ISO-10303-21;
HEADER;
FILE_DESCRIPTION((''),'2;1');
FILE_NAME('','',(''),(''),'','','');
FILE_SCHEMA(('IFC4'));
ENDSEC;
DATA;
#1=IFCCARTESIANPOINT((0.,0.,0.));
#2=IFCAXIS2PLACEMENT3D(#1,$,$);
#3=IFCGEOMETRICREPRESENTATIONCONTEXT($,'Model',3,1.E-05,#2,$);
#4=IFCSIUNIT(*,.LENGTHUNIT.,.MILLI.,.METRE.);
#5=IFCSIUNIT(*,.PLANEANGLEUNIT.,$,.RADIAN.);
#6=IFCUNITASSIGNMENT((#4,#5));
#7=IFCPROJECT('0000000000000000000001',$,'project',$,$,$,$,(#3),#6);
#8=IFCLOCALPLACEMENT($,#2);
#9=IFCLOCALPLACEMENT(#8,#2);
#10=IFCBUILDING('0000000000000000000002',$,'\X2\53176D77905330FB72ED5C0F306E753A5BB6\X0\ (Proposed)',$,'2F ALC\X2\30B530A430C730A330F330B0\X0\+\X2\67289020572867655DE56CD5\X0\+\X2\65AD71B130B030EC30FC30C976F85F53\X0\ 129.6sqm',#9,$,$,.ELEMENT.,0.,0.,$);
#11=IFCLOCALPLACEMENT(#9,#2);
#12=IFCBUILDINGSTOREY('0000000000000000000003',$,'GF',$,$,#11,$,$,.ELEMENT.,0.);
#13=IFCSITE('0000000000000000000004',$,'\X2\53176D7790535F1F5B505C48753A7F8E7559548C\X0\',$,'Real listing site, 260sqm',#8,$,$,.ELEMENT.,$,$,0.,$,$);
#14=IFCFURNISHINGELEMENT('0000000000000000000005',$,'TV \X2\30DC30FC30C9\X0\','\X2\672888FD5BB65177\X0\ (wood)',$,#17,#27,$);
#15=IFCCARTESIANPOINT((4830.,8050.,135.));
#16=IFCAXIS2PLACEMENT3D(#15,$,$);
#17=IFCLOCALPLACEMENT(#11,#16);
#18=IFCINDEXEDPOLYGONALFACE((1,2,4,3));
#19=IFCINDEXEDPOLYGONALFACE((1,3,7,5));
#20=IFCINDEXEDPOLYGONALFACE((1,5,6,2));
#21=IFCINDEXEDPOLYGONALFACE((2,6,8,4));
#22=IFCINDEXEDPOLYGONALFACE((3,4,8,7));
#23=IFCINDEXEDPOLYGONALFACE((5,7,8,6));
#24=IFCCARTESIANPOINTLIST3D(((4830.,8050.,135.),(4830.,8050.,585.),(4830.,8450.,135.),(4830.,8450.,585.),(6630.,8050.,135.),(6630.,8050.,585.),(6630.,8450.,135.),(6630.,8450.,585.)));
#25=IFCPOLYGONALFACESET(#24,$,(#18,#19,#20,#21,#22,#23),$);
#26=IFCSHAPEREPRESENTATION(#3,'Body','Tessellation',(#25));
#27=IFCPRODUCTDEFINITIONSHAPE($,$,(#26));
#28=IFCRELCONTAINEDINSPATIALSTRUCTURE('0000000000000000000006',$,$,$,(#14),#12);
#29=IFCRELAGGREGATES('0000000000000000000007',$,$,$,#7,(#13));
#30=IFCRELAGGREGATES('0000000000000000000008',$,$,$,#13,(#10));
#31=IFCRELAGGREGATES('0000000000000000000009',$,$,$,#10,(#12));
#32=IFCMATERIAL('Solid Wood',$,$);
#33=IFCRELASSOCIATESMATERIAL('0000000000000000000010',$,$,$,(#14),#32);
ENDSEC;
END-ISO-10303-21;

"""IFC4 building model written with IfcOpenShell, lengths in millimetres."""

from ifc_helpers import new_model, si_unit, frame, frame_2d, origin, place, context, project, spatial, rectangle, extrude, material, element, save


model = new_model("IFC4")

# Units and contexts
model_context = context("Model", 3, precision=1e-05, world=origin())
ifc_project = project(units=[si_unit("LENGTHUNIT", "METRE", prefix="MILLI"), si_unit("PLANEANGLEUNIT", "RADIAN")], contexts=[model_context])

# Site, building, storey
site_placement = place(None, origin())
site = spatial("IfcSite", under=ifc_project, at=site_placement, Name="北海道弟子屈町美留和", ObjectType="Real listing site, 260sqm", CompositionType="ELEMENT", RefElevation=0.0)
building_placement = place(site_placement, origin())
building = spatial("IfcBuilding", under=site, at=building_placement, Name="北海道・狭小の町家 (Proposed)", ObjectType="2F ALCサイディング+木造在来工法+断熱グレード相当 129.6sqm", CompositionType="ELEMENT", ElevationOfRefHeight=0.0, ElevationOfTerrain=0.0)
storey_placement = place(building_placement, origin())
storey = spatial("IfcBuildingStorey", under=building, at=storey_placement, Name="GF", CompositionType="ELEMENT", Elevation=0.0)

# Shared definitions
ifc_material_1 = material(Name="Solid Wood")

# Furnishing element
furnishing_placement = place(storey_placement, frame((4830.0, 8050.0, 135.0)))
element("IfcFurnishingElement", 1, at=furnishing_placement, inside=storey, material=ifc_material_1, Name="TV ボード", Description="木製家具 (wood)", context=model_context, shape_type="SweptSolid", body=[
    extrude(rectangle(XDim=1800.0, YDim=400.0, at=frame_2d((900.0, 200.0))), frame((4830.0, 8050.0, 135.0)), (0.0, 0.0, 1.0), 450.0),
])

save(model, "model.ifc")
